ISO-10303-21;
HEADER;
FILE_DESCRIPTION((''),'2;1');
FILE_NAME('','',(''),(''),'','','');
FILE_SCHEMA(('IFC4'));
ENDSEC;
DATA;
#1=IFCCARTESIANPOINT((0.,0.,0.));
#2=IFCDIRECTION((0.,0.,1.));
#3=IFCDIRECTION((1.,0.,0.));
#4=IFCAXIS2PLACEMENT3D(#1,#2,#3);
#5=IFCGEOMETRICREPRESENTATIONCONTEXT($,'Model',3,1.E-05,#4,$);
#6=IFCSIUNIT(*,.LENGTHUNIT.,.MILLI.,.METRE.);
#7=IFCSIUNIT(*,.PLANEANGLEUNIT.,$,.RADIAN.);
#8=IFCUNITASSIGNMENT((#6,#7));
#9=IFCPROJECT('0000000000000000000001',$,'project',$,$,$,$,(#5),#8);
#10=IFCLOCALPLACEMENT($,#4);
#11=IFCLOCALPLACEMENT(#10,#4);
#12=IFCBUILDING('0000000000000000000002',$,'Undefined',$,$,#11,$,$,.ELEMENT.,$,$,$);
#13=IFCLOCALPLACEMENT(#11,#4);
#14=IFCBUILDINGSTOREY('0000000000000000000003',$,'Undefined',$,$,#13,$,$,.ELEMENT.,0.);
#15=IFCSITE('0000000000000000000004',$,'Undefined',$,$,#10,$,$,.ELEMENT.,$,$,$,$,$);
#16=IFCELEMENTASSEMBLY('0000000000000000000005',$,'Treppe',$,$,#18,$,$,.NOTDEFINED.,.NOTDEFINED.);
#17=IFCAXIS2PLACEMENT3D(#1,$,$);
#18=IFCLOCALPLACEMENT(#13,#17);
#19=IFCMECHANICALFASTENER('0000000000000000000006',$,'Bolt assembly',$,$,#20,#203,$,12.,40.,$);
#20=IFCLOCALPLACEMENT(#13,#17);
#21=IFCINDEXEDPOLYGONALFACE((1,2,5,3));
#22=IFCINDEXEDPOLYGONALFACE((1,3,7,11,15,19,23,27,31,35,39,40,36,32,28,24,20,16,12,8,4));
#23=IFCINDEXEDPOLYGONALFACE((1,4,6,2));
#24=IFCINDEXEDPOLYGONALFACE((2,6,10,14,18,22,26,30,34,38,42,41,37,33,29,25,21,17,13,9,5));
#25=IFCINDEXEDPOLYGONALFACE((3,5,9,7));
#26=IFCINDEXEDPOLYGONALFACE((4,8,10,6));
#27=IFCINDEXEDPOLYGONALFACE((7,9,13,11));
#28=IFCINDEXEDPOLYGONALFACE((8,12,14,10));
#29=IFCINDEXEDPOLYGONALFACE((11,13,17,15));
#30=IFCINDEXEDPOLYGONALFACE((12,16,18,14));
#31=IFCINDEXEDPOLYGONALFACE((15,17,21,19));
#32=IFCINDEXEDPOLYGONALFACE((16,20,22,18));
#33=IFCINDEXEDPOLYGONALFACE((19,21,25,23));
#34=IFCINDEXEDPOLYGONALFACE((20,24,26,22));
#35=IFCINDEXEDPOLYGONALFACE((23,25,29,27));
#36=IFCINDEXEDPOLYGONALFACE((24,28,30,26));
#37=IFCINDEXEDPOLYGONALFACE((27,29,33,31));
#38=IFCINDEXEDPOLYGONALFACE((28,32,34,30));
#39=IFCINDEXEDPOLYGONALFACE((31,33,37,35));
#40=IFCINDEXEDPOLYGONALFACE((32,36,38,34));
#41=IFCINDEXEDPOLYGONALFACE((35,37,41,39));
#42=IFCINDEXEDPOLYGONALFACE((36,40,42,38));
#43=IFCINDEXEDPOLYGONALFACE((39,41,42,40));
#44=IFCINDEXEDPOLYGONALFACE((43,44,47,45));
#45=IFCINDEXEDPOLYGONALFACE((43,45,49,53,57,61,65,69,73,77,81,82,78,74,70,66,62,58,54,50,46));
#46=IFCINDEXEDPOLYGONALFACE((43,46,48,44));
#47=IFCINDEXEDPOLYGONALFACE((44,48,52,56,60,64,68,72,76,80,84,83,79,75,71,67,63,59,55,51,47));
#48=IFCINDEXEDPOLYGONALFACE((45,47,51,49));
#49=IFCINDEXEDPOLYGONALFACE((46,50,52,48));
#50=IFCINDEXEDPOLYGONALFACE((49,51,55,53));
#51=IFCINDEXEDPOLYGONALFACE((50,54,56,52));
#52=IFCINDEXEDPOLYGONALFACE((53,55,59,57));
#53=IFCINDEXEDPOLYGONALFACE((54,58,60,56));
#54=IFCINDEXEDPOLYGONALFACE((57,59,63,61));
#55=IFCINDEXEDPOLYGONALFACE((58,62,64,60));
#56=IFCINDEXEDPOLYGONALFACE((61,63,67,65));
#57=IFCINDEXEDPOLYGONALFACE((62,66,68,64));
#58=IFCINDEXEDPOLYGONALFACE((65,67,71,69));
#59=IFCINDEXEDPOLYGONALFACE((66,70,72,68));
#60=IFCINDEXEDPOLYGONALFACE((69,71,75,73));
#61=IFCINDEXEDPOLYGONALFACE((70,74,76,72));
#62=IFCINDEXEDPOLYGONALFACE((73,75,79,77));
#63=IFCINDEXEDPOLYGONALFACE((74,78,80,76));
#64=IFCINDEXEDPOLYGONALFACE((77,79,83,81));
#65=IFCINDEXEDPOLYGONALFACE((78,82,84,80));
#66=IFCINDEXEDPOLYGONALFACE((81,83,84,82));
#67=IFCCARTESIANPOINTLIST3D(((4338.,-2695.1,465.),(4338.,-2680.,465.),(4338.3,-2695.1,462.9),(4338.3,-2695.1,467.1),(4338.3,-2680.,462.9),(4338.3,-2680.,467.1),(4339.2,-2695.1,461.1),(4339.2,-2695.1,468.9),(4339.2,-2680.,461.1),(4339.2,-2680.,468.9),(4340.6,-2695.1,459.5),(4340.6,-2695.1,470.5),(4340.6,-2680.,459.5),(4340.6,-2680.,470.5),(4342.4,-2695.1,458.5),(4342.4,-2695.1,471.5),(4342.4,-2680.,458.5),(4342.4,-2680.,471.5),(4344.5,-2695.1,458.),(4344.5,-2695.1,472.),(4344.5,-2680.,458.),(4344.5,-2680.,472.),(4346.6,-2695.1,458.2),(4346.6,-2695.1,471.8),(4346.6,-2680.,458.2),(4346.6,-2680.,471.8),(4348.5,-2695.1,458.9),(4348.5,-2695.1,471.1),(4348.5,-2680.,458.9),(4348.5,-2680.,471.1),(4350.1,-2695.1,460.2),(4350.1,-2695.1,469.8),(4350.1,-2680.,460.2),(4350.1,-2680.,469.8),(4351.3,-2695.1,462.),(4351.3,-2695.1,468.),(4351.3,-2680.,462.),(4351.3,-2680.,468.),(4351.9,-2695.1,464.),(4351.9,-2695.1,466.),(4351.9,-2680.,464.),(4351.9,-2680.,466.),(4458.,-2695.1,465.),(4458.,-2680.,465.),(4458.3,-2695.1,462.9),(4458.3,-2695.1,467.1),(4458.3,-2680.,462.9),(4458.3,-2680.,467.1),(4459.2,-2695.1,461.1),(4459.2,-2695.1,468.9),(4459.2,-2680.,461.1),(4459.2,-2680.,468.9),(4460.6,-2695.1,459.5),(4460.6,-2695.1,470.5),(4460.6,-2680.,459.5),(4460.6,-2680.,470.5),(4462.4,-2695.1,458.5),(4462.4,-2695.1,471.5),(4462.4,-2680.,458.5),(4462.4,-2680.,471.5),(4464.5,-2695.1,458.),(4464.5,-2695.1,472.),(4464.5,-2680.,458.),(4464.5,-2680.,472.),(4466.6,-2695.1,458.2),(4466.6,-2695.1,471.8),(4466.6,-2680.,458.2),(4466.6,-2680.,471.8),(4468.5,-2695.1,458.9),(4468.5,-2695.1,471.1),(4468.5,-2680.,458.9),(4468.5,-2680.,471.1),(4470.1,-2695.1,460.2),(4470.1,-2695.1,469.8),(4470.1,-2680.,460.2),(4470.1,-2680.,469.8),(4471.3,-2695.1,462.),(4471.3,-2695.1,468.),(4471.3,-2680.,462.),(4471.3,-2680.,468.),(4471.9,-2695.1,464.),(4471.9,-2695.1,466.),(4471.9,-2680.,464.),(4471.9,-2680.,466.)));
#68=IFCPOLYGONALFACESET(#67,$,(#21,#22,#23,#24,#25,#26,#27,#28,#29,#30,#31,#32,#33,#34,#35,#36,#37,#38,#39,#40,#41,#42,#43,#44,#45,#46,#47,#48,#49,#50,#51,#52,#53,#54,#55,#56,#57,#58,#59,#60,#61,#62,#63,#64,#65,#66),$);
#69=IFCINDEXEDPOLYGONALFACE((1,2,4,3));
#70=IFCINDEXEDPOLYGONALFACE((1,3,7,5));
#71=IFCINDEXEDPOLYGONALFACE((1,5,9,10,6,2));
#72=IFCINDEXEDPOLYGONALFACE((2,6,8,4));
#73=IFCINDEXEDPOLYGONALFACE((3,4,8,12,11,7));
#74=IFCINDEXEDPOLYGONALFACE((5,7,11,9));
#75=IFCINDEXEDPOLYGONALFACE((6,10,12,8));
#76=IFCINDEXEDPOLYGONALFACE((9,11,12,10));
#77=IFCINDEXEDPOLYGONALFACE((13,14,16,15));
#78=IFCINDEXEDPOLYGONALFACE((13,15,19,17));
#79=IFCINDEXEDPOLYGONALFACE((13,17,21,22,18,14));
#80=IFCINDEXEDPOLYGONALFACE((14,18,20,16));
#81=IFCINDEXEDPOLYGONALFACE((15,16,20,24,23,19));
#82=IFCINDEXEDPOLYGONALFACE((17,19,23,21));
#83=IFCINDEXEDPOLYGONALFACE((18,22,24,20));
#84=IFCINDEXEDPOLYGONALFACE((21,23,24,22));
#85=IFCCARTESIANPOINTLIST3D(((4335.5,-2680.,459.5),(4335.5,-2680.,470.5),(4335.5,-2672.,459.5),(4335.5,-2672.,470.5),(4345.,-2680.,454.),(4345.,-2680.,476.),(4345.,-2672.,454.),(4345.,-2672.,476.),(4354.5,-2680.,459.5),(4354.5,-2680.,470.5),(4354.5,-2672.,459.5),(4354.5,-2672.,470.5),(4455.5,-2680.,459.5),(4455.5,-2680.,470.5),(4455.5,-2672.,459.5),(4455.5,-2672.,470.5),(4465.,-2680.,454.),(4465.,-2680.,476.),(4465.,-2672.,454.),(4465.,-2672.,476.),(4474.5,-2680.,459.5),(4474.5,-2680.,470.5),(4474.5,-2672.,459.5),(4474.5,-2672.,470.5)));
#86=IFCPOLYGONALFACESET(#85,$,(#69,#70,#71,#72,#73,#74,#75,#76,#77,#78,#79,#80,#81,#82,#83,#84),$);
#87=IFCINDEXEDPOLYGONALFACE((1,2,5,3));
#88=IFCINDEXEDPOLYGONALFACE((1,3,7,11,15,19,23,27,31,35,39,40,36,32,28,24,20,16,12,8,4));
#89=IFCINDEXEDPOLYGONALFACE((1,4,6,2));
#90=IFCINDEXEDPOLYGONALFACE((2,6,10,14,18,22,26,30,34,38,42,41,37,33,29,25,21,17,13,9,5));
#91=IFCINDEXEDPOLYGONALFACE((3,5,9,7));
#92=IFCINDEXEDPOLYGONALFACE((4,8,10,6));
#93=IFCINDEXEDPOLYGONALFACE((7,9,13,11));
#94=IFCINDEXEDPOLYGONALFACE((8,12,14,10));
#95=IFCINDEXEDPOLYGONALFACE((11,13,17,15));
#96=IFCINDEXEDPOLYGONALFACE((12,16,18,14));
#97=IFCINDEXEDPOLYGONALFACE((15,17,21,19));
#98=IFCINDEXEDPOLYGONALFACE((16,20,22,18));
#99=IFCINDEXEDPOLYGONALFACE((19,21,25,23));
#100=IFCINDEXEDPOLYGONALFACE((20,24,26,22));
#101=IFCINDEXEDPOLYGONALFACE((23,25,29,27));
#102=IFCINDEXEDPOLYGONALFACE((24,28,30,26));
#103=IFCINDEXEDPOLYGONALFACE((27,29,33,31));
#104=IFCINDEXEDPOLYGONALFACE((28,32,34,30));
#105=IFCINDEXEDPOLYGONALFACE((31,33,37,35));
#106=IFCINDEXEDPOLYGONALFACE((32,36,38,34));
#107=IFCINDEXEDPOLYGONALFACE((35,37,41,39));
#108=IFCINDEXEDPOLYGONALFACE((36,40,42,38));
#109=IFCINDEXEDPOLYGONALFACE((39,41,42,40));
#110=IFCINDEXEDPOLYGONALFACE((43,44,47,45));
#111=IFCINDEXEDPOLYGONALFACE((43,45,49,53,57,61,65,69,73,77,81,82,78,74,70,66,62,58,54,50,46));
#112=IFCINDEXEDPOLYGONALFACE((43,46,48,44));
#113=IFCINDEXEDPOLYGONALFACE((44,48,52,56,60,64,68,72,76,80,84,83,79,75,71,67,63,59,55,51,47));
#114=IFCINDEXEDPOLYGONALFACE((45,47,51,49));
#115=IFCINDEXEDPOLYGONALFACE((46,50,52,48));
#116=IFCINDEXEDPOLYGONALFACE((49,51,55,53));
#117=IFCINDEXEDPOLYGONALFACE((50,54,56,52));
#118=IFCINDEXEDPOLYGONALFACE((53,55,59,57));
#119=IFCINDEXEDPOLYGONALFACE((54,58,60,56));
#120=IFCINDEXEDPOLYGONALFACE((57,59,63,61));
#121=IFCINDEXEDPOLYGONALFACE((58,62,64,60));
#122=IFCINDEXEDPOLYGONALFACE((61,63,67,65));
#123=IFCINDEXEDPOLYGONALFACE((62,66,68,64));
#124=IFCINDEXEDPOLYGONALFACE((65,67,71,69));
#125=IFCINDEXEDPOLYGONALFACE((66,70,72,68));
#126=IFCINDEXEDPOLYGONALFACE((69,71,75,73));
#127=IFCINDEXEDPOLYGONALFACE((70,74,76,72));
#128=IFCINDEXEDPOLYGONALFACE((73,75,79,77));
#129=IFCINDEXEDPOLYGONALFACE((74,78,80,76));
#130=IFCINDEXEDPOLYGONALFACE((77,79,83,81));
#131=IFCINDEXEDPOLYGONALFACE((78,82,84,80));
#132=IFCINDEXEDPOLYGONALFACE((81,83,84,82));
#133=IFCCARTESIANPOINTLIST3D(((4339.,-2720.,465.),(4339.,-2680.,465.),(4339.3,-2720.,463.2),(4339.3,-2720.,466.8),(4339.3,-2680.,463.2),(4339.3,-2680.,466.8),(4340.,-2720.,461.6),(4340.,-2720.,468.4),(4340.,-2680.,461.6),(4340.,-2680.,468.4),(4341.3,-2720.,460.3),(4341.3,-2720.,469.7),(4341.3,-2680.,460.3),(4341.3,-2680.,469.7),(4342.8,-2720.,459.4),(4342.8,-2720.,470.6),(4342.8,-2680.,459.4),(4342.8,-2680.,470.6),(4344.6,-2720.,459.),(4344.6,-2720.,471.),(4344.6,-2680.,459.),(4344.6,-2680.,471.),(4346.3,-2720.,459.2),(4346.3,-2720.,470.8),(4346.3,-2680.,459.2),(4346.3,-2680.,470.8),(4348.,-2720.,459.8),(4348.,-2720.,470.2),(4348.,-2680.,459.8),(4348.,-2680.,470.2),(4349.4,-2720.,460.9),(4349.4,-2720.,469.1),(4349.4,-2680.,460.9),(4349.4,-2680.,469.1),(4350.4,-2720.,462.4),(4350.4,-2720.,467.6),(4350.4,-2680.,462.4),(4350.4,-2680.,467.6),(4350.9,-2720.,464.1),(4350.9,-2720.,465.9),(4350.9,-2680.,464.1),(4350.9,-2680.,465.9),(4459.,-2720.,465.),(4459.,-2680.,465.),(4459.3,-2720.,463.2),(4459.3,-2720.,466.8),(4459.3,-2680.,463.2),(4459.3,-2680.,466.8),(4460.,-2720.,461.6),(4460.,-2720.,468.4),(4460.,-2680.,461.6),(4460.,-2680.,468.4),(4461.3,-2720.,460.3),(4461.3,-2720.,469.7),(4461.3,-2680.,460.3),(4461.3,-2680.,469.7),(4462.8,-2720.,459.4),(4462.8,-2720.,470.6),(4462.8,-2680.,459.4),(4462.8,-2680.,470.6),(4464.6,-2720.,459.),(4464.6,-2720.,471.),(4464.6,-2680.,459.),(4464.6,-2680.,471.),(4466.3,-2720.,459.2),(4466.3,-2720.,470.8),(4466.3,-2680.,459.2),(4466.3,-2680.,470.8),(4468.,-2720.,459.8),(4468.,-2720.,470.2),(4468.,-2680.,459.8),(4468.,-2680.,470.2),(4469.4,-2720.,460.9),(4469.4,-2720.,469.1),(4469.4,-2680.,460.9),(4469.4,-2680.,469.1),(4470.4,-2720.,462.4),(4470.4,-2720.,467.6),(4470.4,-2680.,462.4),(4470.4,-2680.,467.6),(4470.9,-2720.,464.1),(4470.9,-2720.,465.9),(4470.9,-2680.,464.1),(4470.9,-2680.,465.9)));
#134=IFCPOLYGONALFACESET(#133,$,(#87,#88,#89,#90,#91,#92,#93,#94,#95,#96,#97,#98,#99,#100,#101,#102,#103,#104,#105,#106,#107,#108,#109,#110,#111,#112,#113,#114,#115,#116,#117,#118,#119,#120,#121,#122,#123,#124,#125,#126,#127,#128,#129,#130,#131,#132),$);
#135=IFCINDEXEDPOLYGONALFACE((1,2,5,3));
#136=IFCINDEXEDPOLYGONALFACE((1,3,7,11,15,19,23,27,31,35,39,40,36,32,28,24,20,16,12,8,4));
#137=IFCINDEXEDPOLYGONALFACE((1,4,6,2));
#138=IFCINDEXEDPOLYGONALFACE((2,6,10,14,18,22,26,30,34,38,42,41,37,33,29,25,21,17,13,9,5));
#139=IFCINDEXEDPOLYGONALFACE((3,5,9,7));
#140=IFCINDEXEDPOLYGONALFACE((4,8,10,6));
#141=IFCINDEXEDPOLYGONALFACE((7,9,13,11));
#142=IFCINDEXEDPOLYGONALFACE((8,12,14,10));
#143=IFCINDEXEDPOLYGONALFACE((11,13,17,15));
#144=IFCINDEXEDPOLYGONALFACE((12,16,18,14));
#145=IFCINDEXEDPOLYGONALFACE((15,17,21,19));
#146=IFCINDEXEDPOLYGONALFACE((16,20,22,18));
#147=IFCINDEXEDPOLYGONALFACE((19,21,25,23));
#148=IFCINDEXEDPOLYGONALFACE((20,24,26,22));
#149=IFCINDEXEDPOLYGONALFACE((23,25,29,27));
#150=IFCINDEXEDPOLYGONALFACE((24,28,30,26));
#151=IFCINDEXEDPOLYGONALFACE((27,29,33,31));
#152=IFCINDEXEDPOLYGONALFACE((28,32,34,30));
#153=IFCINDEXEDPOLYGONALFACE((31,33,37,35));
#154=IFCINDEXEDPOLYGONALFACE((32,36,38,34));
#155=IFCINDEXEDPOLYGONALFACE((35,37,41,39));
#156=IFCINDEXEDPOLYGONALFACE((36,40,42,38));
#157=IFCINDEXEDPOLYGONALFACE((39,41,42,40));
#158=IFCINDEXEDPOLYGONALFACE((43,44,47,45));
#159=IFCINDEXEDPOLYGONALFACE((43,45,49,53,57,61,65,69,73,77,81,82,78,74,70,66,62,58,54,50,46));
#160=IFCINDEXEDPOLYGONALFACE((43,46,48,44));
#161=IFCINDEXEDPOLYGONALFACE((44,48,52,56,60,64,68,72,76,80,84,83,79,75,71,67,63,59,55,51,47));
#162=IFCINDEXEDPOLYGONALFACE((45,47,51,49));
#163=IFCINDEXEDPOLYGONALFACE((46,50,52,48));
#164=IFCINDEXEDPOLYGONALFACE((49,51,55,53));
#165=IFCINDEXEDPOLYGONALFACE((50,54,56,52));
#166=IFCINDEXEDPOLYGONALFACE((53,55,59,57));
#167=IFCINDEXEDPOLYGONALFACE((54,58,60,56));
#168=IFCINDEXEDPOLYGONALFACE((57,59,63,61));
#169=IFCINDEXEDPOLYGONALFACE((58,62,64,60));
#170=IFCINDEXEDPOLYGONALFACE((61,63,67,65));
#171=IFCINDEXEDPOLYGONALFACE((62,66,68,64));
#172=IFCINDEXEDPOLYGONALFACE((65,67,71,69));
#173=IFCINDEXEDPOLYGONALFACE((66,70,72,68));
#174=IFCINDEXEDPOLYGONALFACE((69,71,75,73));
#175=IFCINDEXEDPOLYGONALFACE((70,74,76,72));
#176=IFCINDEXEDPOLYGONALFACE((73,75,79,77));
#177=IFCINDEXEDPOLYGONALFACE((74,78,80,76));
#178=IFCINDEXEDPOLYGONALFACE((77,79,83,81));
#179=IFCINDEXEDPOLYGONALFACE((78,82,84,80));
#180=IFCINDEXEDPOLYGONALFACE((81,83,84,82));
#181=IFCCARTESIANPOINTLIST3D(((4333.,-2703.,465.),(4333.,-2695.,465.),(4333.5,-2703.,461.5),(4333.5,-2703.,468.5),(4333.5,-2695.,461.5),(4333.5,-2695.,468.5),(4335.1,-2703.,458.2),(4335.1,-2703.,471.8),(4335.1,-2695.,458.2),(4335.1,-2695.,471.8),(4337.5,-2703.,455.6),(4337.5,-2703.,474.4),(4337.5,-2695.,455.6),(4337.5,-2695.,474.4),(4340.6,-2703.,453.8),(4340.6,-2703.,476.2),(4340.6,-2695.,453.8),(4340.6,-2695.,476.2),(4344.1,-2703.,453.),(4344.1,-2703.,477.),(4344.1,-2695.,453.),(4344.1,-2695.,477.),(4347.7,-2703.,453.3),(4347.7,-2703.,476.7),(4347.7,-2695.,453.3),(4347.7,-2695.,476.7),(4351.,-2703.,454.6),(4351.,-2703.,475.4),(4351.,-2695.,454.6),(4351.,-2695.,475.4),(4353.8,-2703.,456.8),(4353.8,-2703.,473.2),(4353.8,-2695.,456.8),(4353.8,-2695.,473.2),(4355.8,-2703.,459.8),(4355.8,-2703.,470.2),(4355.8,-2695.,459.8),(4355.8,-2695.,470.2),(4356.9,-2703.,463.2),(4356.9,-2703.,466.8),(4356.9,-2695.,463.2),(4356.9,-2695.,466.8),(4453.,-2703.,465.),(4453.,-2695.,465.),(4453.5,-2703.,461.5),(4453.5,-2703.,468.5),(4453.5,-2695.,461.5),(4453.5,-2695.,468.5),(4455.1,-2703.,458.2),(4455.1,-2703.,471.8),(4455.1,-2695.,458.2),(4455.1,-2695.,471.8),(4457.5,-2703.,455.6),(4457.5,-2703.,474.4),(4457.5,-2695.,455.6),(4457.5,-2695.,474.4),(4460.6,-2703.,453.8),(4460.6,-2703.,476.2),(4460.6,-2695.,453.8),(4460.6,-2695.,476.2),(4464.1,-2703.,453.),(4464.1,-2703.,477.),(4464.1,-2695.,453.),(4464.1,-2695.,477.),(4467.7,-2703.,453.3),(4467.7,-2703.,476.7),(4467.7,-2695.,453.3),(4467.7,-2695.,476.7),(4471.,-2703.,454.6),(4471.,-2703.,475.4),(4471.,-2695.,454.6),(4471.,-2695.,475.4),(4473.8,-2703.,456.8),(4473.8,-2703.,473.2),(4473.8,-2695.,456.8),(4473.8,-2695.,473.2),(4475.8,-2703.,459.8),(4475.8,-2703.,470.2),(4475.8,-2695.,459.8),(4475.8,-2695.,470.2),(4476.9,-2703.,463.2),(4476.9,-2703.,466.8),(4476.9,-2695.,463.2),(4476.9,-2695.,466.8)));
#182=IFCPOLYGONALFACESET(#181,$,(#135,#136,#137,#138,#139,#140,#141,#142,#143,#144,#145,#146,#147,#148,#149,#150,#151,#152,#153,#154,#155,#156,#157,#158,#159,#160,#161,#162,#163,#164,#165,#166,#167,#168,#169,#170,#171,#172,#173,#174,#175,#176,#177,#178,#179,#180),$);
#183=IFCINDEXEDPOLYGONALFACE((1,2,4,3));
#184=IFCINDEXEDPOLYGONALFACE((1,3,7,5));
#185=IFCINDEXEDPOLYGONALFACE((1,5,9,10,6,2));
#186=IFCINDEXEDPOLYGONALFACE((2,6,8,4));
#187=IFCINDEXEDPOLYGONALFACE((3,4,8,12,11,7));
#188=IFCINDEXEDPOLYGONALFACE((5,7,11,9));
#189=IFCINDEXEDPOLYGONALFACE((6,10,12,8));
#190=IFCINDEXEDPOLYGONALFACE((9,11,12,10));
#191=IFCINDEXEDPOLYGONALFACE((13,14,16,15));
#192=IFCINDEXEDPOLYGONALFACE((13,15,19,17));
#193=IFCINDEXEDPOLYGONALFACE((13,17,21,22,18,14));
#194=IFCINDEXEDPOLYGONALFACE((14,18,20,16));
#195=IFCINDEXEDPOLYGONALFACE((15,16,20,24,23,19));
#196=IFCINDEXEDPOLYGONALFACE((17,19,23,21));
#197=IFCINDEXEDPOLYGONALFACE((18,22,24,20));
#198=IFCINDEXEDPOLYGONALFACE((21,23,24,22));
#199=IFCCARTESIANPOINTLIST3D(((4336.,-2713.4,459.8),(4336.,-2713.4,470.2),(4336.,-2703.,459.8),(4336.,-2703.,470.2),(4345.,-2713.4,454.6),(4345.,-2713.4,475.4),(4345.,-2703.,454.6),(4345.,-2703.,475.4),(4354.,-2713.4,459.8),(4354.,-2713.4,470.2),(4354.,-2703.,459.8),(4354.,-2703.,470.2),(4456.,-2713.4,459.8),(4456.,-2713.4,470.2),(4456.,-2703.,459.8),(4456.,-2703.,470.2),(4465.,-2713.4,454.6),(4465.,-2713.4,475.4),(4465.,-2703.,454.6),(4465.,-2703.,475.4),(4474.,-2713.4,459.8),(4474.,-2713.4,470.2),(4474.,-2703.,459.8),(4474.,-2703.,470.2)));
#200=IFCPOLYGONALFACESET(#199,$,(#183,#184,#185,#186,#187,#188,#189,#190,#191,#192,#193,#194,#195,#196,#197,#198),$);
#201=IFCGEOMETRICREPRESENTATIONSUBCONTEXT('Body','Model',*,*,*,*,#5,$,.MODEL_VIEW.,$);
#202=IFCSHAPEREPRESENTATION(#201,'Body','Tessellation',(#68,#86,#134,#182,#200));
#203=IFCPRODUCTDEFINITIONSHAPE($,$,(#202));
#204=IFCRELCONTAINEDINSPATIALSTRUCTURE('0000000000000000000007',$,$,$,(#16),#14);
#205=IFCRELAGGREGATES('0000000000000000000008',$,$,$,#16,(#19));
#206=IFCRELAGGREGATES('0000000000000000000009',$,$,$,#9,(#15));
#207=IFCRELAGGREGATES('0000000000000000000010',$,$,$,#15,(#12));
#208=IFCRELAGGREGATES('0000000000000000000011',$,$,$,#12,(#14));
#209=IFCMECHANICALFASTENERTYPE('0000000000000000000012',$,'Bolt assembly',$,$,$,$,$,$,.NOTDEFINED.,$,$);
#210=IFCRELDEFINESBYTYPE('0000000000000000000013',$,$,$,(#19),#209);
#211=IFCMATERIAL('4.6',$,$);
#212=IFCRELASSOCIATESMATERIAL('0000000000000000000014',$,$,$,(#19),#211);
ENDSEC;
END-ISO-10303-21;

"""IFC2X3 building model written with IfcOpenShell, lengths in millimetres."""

from ifc_helpers import new_model, si_unit, frame, origin_with_axes, origin_2d_with_axis, place, context, subcontext, project, spatial, polyline, circle, outline, extrude, source, transform, mapped, material, type_object, element, aggregate, save


model = new_model("IFC2X3")

# Units and contexts
model_context = context("Model", 3, precision=1e-05, world=origin_with_axes())
body_context = subcontext(model_context, "Body", "Model", "MODEL_VIEW")
ifc_project = project(units=[si_unit("LENGTHUNIT", "METRE", prefix="MILLI"), si_unit("PLANEANGLEUNIT", "RADIAN")], contexts=[model_context])

# Site, building, storey
site_placement = place(None, origin_with_axes())
site = spatial("IfcSite", under=ifc_project, at=site_placement, Name="Undefined", CompositionType="ELEMENT")
building_placement = place(site_placement, origin_with_axes())
building = spatial("IfcBuilding", under=site, at=building_placement, Name="Undefined", CompositionType="ELEMENT")
storey_placement = place(building_placement, origin_with_axes())
storey = spatial("IfcBuildingStorey", under=building, at=storey_placement, Name="Undefined", CompositionType="ELEMENT", Elevation=0.0)

# Element assembly, mechanical fastener
ifc_material_1 = material(Name="4.6")
mechanical_fastener_type = type_object("IfcMechanicalFastenerType", Name="Bolt assembly")
assembly_1_placement = place(storey_placement, origin_with_axes())
assembly_1 = element("IfcElementAssembly", 1, at=assembly_1_placement, inside=storey, Name="Treppe", AssemblyPlace="NOTDEFINED", PredefinedType="NOTDEFINED")
shared_shape_1 = source(origin_with_axes(), body_context, "Body", "SweptSolid", [
    extrude(circle(Radius=7.0, at=origin_2d_with_axis()), frame((0.0, -15.0, 0.0), z_axis=(0.0, 1.0, 0.0), x_axis=(1.0, 0.0, 0.0)), (0.0, 0.0, 1.0), 15.1),
    extrude(outline(polyline([(9.5, -5.5), (9.5, 5.5), (0.0, 11.0), (-9.5, 5.5), (-9.5, -5.5), (0.0, -11.0), (9.5, -5.5)])), frame((0.0, -23.0, 0.0), z_axis=(0.0, 1.0, 0.0), x_axis=(1.0, 0.0, 0.0)), (0.0, 0.0, 1.0), 8.0),
    extrude(circle(Radius=6.0, at=origin_2d_with_axis()), frame((0.0, -15.0, 0.0), z_axis=(0.0, 1.0, 0.0), x_axis=(1.0, 0.0, 0.0)), (0.0, 0.0, 1.0), 40.0),
    extrude(circle(Radius=12.0, at=origin_2d_with_axis()), frame((0.0, 0.0, 0.0), z_axis=(0.0, 1.0, 0.0), x_axis=(1.0, 0.0, 0.0)), (0.0, 0.0, 1.0), 8.0),
    extrude(outline(polyline([(9.0, -5.2), (9.0, 5.2), (0.0, 10.4), (-9.0, 5.2), (-9.0, -5.2), (0.0, -10.4), (9.0, -5.2)])), frame((0.0, 8.0, 0.0), z_axis=(0.0, 1.0, 0.0), x_axis=(1.0, 0.0, 0.0)), (0.0, 0.0, 1.0), 10.4),
])
mechanical_fastener_1_placement = place(assembly_1_placement, frame((4465.0, -2695.0, 465.0), z_axis=(0.0, 0.0, 1.0), x_axis=(-1.0, 0.0, 0.0)))
mechanical_fastener_1 = element("IfcMechanicalFastener", 2, at=mechanical_fastener_1_placement, type_object=mechanical_fastener_type, material=ifc_material_1, Name="Bolt assembly", NominalDiameter=12.0, NominalLength=40.0, context=body_context, shape_type="MappedRepresentation", body=[
    mapped(shared_shape_1, transform((0.0, 0.0, 0.0))),
    mapped(shared_shape_1, transform((120.0, 0.0, 0.0))),
])
aggregate(assembly_1, [mechanical_fastener_1])

save(model, "model.ifc")
